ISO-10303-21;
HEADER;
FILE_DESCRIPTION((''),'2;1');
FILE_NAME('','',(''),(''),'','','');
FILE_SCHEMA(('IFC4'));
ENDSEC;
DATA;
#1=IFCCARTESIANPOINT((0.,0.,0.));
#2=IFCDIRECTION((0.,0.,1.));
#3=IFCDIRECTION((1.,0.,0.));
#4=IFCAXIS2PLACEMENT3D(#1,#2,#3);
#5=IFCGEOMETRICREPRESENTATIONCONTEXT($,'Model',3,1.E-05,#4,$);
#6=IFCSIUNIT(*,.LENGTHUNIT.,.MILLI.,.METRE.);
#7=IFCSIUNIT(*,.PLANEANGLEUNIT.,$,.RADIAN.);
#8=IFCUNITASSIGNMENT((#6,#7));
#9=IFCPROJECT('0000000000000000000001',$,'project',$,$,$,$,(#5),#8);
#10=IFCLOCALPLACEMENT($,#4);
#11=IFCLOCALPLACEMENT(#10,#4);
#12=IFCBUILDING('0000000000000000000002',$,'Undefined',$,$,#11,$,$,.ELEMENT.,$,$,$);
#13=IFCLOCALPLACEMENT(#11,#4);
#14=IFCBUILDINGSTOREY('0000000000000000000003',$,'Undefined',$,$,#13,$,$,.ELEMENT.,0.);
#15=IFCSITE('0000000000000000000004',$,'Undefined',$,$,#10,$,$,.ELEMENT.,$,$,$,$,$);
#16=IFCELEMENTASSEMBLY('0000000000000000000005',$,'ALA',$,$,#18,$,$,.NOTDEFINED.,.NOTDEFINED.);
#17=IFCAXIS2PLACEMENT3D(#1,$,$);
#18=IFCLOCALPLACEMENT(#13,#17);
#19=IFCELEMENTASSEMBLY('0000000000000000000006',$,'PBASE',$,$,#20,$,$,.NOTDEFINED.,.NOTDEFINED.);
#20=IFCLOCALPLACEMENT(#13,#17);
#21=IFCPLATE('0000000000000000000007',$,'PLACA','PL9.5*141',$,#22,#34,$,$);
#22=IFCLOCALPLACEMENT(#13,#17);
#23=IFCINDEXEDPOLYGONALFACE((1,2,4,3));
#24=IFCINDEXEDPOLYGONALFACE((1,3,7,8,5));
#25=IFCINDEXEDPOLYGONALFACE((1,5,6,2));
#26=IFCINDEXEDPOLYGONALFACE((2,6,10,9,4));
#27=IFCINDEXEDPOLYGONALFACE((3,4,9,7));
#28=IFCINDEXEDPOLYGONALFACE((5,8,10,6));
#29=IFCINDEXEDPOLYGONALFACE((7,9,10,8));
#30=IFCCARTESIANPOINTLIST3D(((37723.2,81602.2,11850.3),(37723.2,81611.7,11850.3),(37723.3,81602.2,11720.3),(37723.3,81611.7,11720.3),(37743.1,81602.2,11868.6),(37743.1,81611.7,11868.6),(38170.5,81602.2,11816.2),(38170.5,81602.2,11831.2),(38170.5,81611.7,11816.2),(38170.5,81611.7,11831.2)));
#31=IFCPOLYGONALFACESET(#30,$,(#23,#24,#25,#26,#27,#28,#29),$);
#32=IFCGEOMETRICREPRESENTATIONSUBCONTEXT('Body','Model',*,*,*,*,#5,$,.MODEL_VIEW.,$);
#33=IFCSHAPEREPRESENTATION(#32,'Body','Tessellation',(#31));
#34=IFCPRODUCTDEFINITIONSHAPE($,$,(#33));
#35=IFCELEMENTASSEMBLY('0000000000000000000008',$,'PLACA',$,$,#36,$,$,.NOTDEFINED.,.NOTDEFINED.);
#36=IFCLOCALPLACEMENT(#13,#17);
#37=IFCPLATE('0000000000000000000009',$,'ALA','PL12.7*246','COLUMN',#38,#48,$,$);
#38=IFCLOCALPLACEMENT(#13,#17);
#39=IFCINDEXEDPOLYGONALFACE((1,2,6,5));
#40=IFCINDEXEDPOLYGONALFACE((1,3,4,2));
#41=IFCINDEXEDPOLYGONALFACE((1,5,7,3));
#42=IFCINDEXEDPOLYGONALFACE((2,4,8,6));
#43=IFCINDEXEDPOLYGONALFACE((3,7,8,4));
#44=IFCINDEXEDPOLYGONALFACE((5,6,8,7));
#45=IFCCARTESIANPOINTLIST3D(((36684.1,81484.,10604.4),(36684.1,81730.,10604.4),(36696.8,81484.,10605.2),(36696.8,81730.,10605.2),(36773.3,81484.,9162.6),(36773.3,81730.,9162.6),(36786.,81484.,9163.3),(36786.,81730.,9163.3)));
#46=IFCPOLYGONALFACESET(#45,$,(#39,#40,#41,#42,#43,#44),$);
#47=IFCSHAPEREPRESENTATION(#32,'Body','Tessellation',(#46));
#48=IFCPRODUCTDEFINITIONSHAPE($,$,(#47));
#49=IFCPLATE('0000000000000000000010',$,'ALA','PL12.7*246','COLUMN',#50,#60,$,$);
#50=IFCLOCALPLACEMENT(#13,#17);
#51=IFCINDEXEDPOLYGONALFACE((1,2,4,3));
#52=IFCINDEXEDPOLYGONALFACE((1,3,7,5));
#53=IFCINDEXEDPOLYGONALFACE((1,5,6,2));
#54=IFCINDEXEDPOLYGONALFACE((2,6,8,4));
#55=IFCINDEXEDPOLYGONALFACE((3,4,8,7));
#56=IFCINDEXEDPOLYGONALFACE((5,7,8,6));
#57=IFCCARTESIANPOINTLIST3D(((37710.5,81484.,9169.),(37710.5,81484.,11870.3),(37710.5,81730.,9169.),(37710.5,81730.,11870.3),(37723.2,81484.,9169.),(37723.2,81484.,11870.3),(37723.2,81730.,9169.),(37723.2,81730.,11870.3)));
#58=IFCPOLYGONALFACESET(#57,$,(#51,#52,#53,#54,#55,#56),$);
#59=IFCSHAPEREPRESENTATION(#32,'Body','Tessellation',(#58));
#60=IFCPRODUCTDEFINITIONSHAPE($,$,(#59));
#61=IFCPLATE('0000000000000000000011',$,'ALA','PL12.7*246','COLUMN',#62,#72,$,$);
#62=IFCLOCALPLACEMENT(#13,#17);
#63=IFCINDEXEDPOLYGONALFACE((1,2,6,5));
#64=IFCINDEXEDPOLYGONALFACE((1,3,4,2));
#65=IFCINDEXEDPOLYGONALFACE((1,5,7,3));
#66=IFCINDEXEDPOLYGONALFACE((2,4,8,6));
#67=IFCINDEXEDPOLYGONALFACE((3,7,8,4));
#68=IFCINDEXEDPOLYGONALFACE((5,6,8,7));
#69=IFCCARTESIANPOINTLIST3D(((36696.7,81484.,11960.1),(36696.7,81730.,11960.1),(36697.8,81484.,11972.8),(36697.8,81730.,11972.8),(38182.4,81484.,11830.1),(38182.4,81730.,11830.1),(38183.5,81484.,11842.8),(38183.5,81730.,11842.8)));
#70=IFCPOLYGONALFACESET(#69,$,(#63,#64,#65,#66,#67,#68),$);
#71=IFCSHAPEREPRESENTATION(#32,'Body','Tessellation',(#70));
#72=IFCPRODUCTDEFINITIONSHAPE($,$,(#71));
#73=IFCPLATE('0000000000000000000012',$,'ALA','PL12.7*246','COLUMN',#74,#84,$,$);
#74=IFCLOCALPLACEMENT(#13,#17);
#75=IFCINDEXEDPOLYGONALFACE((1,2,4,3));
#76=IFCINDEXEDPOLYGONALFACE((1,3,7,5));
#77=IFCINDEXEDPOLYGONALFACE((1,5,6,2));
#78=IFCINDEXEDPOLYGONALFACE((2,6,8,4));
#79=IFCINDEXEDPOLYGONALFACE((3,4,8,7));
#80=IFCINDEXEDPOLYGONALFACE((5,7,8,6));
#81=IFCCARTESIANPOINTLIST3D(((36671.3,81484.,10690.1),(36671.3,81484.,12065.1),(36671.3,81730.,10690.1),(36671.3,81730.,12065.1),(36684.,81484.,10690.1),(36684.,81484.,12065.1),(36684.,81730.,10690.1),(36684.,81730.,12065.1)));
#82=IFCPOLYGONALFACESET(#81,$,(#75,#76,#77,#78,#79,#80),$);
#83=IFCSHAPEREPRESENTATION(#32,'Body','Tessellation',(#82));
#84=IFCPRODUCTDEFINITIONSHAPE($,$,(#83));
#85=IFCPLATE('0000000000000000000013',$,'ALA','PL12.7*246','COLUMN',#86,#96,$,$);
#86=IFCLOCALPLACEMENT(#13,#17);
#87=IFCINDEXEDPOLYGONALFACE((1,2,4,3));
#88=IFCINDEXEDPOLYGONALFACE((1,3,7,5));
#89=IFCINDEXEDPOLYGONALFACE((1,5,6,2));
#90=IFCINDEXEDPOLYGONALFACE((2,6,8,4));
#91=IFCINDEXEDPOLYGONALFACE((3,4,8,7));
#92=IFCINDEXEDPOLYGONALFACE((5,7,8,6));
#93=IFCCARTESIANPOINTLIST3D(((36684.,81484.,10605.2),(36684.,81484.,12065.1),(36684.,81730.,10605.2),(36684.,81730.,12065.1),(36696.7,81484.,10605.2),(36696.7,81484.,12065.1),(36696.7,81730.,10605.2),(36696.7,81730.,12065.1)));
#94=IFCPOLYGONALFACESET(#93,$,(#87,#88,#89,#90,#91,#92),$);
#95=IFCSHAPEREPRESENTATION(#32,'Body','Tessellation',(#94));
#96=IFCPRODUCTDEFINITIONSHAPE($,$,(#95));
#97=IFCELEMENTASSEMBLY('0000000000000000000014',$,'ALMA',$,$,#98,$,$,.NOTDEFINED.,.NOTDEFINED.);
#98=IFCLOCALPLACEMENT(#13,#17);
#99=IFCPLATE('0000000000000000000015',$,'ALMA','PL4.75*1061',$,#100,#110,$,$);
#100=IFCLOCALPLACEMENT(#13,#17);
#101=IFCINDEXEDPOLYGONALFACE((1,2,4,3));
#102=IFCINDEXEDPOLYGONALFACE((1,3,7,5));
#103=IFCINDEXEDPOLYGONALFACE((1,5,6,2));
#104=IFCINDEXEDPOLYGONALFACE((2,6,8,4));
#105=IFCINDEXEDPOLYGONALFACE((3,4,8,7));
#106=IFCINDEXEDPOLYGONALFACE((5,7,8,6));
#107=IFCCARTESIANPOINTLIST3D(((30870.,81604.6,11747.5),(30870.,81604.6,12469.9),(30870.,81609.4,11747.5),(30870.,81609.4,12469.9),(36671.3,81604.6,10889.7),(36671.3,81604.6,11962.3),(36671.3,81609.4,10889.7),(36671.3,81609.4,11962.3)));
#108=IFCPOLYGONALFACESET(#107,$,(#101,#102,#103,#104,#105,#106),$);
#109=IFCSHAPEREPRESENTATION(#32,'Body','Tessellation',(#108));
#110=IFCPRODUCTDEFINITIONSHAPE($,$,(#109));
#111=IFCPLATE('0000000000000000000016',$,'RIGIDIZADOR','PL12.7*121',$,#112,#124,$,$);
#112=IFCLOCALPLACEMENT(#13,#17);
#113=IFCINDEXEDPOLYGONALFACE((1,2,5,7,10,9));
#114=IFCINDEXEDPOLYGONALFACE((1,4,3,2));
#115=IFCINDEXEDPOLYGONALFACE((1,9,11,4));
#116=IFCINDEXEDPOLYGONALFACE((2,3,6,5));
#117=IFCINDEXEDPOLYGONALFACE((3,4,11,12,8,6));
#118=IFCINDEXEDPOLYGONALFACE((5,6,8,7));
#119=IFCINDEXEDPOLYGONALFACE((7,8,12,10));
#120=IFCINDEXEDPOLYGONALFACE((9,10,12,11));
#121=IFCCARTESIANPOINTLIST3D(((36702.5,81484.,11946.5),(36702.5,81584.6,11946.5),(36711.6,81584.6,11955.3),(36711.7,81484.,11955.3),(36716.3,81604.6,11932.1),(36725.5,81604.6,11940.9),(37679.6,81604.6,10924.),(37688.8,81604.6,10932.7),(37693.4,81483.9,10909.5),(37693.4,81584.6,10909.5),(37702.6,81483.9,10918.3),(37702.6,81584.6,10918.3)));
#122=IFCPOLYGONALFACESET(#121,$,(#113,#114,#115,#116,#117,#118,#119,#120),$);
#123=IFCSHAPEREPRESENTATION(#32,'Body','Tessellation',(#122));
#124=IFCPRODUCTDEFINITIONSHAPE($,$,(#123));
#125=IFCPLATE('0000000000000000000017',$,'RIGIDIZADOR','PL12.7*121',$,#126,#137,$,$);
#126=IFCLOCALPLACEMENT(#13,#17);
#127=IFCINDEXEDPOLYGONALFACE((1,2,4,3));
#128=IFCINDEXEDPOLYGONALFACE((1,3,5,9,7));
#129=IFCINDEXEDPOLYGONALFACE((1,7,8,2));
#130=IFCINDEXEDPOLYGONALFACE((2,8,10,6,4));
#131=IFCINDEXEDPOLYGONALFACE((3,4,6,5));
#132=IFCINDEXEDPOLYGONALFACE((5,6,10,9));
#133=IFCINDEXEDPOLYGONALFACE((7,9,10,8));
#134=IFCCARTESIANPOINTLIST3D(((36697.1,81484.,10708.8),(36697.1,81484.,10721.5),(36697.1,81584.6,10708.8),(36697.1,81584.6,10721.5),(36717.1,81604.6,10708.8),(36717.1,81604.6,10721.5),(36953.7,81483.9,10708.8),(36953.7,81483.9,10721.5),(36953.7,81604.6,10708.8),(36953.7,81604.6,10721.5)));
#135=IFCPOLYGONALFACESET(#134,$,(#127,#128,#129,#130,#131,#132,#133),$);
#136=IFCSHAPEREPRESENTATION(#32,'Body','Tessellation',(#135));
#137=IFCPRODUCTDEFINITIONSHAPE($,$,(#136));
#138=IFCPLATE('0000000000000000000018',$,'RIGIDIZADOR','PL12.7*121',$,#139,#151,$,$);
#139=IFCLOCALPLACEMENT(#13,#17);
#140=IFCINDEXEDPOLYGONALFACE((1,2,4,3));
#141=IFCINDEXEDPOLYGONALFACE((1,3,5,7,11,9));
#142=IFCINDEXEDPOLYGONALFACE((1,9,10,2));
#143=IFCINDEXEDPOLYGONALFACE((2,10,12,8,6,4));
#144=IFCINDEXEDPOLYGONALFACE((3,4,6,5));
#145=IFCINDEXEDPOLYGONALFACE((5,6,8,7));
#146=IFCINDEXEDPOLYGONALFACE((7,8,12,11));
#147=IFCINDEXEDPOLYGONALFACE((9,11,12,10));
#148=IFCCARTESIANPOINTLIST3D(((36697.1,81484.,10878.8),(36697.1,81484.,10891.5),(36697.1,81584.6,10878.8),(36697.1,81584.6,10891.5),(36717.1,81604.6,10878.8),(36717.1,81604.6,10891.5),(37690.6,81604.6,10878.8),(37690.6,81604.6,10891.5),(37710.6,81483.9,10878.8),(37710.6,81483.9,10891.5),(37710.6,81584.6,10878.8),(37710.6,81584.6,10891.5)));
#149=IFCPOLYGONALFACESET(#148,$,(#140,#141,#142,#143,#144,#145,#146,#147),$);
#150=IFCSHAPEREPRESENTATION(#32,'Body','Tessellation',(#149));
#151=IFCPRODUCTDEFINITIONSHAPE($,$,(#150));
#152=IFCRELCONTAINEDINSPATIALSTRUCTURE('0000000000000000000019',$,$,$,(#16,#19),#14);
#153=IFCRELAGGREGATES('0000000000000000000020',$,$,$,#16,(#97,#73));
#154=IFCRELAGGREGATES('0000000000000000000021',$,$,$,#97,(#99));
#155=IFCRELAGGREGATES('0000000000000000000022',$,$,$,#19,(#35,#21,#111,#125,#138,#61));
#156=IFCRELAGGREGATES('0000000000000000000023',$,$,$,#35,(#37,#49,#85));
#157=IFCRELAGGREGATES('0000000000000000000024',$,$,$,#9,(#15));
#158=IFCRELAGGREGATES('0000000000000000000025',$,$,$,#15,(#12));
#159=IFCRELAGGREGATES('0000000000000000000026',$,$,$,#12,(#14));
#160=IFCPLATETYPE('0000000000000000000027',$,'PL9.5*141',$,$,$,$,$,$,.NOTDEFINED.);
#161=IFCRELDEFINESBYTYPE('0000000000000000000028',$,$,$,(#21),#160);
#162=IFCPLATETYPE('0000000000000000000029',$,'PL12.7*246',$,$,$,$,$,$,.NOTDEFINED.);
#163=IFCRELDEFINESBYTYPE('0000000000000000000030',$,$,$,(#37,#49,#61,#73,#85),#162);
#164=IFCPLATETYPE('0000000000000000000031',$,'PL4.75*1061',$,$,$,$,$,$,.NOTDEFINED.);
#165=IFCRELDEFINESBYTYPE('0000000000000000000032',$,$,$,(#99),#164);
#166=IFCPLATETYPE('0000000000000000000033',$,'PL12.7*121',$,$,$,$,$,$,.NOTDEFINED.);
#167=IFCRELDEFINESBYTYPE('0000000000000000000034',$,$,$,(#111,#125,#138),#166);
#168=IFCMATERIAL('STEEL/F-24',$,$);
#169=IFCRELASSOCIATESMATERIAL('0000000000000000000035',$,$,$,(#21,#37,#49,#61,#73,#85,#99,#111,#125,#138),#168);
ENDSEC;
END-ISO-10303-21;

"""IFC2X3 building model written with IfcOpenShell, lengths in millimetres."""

from ifc_helpers import new_model, si_unit, frame, origin_with_axes, place, context, subcontext, project, spatial, polyline, outline, extrude, material, type_object, element, aggregate, save


model = new_model("IFC2X3")

# Units and contexts
model_context = context("Model", 3, precision=1e-05, world=origin_with_axes())
body_context = subcontext(model_context, "Body", "Model", "MODEL_VIEW")
ifc_project = project(units=[si_unit("LENGTHUNIT", "METRE", prefix="MILLI"), si_unit("PLANEANGLEUNIT", "RADIAN")], contexts=[model_context])

# Site, building, storey
site_placement = place(None, origin_with_axes())
site = spatial("IfcSite", under=ifc_project, at=site_placement, Name="Undefined", CompositionType="ELEMENT")
building_placement = place(site_placement, origin_with_axes())
building = spatial("IfcBuilding", under=site, at=building_placement, Name="Undefined", CompositionType="ELEMENT")
storey_placement = place(building_placement, origin_with_axes())
storey = spatial("IfcBuildingStorey", under=building, at=storey_placement, Name="Undefined", CompositionType="ELEMENT", Elevation=0.0)

# Element assembly
assembly_1_placement = place(storey_placement, origin_with_axes())
assembly_1 = element("IfcElementAssembly", 1, at=assembly_1_placement, inside=storey, Name="ALA", AssemblyPlace="NOTDEFINED", PredefinedType="NOTDEFINED")
ifc_material_1 = material(Name="STEEL/F-24")

# Element assembly
assembly_2_placement = place(storey_placement, origin_with_axes())
assembly_2 = element("IfcElementAssembly", 2, at=assembly_2_placement, inside=storey, Name="PBASE", AssemblyPlace="NOTDEFINED", PredefinedType="NOTDEFINED")

# Plate
plate_type_1 = type_object("IfcPlateType", Name="PL9.5*141", PredefinedType="NOTDEFINED")
plate_1_placement = place(assembly_2_placement, frame((38170.5, 81606.9, 11831.2), z_axis=(0.0, 1.0, 0.0), x_axis=(0.0, 0.0, -1.0)))
plate_1 = element("IfcPlate", 3, at=plate_1_placement, type_object=plate_type_1, material=ifc_material_1, Name="PLACA", Description="PL9.5*141", context=body_context, shape_type="SweptSolid", body=[
    extrude(outline(polyline([(0.0, 0.0), (15.0, 0.0), (110.9, 447.1), (-19.1, 447.2), (-37.4, 427.3), (0.0, 0.0)])), frame((0.0, 0.0, -4.8), z_axis=(0.0, 0.0, 1.0), x_axis=(1.0, 0.0, 0.0)), (0.0, 0.0, 1.0), 9.5),
])

# Element assembly, plates
assembly_3_placement = place(assembly_2_placement, origin_with_axes())
assembly_3 = element("IfcElementAssembly", 4, at=assembly_3_placement, Name="PLACA", AssemblyPlace="NOTDEFINED", PredefinedType="NOTDEFINED")
plate_type_2 = type_object("IfcPlateType", Name="PL12.7*246", PredefinedType="NOTDEFINED")
plate_2_placement = place(assembly_3_placement, frame((36779.6, 81607.0, 9162.9), z_axis=(-0.998091, 0.0, -0.061754), x_axis=(-0.061754, 0.0, 0.998091)))
plate_2 = element("IfcPlate", 5, at=plate_2_placement, type_object=plate_type_2, material=ifc_material_1, Name="ALA", Description="PL12.7*246", ObjectType="COLUMN", context=body_context, shape_type="SweptSolid", body=[
    extrude(outline(polyline([(0.0, -123.0), (0.0, 123.0), (1444.6, 123.0), (1444.6, -123.0), (0.0, -123.0)])), frame((0.0, 0.0, -6.3), z_axis=(0.0, 0.0, 1.0), x_axis=(1.0, 0.0, 0.0)), (0.0, 0.0, 1.0), 12.7),
])
plate_3_placement = place(assembly_3_placement, frame((37716.9, 81607.0, 9169.0), z_axis=(-1.0, 0.0, -0.000009), x_axis=(-0.000009, 0.0, 1.0)))
plate_3 = element("IfcPlate", 6, at=plate_3_placement, type_object=plate_type_2, material=ifc_material_1, Name="ALA", Description="PL12.7*246", ObjectType="COLUMN", context=body_context, shape_type="SweptSolid", body=[
    extrude(outline(polyline([(0.0, -123.0), (0.0, 123.0), (2701.3, 123.0), (2701.3, -123.0), (0.0, -123.0)])), frame((0.0, 0.0, -6.3), z_axis=(0.0, 0.0, 1.0), x_axis=(1.0, 0.0, 0.0)), (0.0, 0.0, 1.0), 12.7),
])

# Plates
plate_4_placement = place(assembly_2_placement, frame((36697.3, 81607.0, 11966.5), z_axis=(-0.087151, 0.0, -0.996195), x_axis=(0.996195, 0.0, -0.087151)))
plate_4 = element("IfcPlate", 7, at=plate_4_placement, type_object=plate_type_2, material=ifc_material_1, Name="ALA", Description="PL12.7*246", ObjectType="COLUMN", context=body_context, shape_type="SweptSolid", body=[
    extrude(outline(polyline([(0.0, -123.0), (0.0, 123.0), (1491.4, 123.0), (1491.4, -123.0), (0.0, -123.0)])), frame((0.0, 0.0, -6.3), z_axis=(0.0, 0.0, 1.0), x_axis=(1.0, 0.0, 0.0)), (0.0, 0.0, 1.0), 12.7),
])
plate_5_placement = place(assembly_1_placement, frame((36677.7, 81607.0, 10690.1), z_axis=(-1.0, 0.0, 0.0), x_axis=(0.0, 0.0, 1.0)))
plate_5 = element("IfcPlate", 8, at=plate_5_placement, type_object=plate_type_2, material=ifc_material_1, Name="ALA", Description="PL12.7*246", ObjectType="COLUMN", context=body_context, shape_type="SweptSolid", body=[
    extrude(outline(polyline([(0.0, -123.0), (0.0, 123.0), (1375.0, 123.0), (1375.0, -123.0), (0.0, -123.0)])), frame((0.0, 0.0, -6.3), z_axis=(0.0, 0.0, 1.0), x_axis=(1.0, 0.0, 0.0)), (0.0, 0.0, 1.0), 12.7),
])
plate_6_placement = place(assembly_3_placement, frame((36690.4, 81607.0, 10605.2), z_axis=(-1.0, 0.0, -0.000019), x_axis=(-0.000019, 0.0, 1.0)))
plate_6 = element("IfcPlate", 9, at=plate_6_placement, type_object=plate_type_2, material=ifc_material_1, Name="ALA", Description="PL12.7*246", ObjectType="COLUMN", context=body_context, shape_type="SweptSolid", body=[
    extrude(outline(polyline([(0.0, -123.0), (0.0, 123.0), (1459.9, 123.0), (1459.9, -123.0), (0.0, -123.0)])), frame((0.0, 0.0, -6.3), z_axis=(0.0, 0.0, 1.0), x_axis=(1.0, 0.0, 0.0)), (0.0, 0.0, 1.0), 12.7),
])

# Element assembly
assembly_4_placement = place(assembly_1_placement, origin_with_axes())
assembly_4 = element("IfcElementAssembly", 10, at=assembly_4_placement, Name="ALMA", AssemblyPlace="NOTDEFINED", PredefinedType="NOTDEFINED")
aggregate(assembly_1, [assembly_4, plate_5])

# Plates
plate_type_3 = type_object("IfcPlateType", Name="PL4.75*1061", PredefinedType="NOTDEFINED")
plate_7_placement = place(assembly_4_placement, frame((36671.3, 81607.0, 11962.3), z_axis=(0.0, 1.0, 0.0), x_axis=(-0.000002, 0.0, -1.0)))
plate_7 = element("IfcPlate", 11, at=plate_7_placement, type_object=plate_type_3, material=ifc_material_1, Name="ALMA", Description="PL4.75*1061", context=body_context, shape_type="SweptSolid", body=[
    extrude(outline(polyline([(0.0, 0.0), (1072.6, 0.0), (214.9, 5801.3), (-507.5, 5801.3), (0.0, 0.0)])), frame((0.0, 0.0, -2.4), z_axis=(0.0, 0.0, 1.0), x_axis=(1.0, 0.0, 0.0)), (0.0, 0.0, 1.0), 4.8),
])
aggregate(assembly_4, [plate_7])
plate_type_4 = type_object("IfcPlateType", Name="PL12.7*121", PredefinedType="NOTDEFINED")
plate_8_placement = place(assembly_2_placement, frame((37698.0, 81604.6, 10913.9), z_axis=(-0.722988, 0.0, -0.69086), x_axis=(0.0, -1.0, 0.0)))
plate_8 = element("IfcPlate", 12, at=plate_8_placement, type_object=plate_type_4, material=ifc_material_1, Name="RIGIDIZADOR", Description="PL12.7*121", context=body_context, shape_type="SweptSolid", body=[
    extrude(outline(polyline([(0.0, 20.0), (20.0, 0.0), (120.6, 0.0), (120.6, 1434.4), (20.0, 1434.4), (0.0, 1414.4), (0.0, 20.0)])), frame((0.0, 0.0, -6.3), z_axis=(0.0, 0.0, 1.0), x_axis=(1.0, 0.0, 0.0)), (0.0, 0.0, 1.0), 12.7),
])
plate_9_placement = place(assembly_2_placement, frame((36953.7, 81604.6, 10715.1), z_axis=(0.0, 0.0, -1.0), x_axis=(0.0, -1.0, 0.0)))
plate_9 = element("IfcPlate", 13, at=plate_9_placement, type_object=plate_type_4, material=ifc_material_1, Name="RIGIDIZADOR", Description="PL12.7*121", context=body_context, shape_type="SweptSolid", body=[
    extrude(outline(polyline([(0.0, 0.0), (120.6, 0.0), (120.6, 256.5), (20.0, 256.6), (0.0, 236.6), (0.0, 0.0)])), frame((0.0, 0.0, -6.3), z_axis=(0.0, 0.0, 1.0), x_axis=(1.0, 0.0, 0.0)), (0.0, 0.0, 1.0), 12.7),
])
plate_10_placement = place(assembly_2_placement, frame((37710.6, 81604.6, 10885.1), z_axis=(0.0, 0.0, -1.0), x_axis=(0.0, -1.0, 0.0)))
plate_10 = element("IfcPlate", 14, at=plate_10_placement, type_object=plate_type_4, material=ifc_material_1, Name="RIGIDIZADOR", Description="PL12.7*121", context=body_context, shape_type="SweptSolid", body=[
    extrude(outline(polyline([(0.0, 20.0), (20.0, 0.0), (120.6, 0.0), (120.6, 1013.5), (20.0, 1013.5), (0.0, 993.5), (0.0, 20.0)])), frame((0.0, 0.0, -6.3), z_axis=(0.0, 0.0, 1.0), x_axis=(1.0, 0.0, 0.0)), (0.0, 0.0, 1.0), 12.7),
])
aggregate(assembly_2, [assembly_3, plate_1, plate_8, plate_9, plate_10, plate_4])

aggregate(assembly_3, [plate_2, plate_3, plate_6])

save(model, "model.ifc")
